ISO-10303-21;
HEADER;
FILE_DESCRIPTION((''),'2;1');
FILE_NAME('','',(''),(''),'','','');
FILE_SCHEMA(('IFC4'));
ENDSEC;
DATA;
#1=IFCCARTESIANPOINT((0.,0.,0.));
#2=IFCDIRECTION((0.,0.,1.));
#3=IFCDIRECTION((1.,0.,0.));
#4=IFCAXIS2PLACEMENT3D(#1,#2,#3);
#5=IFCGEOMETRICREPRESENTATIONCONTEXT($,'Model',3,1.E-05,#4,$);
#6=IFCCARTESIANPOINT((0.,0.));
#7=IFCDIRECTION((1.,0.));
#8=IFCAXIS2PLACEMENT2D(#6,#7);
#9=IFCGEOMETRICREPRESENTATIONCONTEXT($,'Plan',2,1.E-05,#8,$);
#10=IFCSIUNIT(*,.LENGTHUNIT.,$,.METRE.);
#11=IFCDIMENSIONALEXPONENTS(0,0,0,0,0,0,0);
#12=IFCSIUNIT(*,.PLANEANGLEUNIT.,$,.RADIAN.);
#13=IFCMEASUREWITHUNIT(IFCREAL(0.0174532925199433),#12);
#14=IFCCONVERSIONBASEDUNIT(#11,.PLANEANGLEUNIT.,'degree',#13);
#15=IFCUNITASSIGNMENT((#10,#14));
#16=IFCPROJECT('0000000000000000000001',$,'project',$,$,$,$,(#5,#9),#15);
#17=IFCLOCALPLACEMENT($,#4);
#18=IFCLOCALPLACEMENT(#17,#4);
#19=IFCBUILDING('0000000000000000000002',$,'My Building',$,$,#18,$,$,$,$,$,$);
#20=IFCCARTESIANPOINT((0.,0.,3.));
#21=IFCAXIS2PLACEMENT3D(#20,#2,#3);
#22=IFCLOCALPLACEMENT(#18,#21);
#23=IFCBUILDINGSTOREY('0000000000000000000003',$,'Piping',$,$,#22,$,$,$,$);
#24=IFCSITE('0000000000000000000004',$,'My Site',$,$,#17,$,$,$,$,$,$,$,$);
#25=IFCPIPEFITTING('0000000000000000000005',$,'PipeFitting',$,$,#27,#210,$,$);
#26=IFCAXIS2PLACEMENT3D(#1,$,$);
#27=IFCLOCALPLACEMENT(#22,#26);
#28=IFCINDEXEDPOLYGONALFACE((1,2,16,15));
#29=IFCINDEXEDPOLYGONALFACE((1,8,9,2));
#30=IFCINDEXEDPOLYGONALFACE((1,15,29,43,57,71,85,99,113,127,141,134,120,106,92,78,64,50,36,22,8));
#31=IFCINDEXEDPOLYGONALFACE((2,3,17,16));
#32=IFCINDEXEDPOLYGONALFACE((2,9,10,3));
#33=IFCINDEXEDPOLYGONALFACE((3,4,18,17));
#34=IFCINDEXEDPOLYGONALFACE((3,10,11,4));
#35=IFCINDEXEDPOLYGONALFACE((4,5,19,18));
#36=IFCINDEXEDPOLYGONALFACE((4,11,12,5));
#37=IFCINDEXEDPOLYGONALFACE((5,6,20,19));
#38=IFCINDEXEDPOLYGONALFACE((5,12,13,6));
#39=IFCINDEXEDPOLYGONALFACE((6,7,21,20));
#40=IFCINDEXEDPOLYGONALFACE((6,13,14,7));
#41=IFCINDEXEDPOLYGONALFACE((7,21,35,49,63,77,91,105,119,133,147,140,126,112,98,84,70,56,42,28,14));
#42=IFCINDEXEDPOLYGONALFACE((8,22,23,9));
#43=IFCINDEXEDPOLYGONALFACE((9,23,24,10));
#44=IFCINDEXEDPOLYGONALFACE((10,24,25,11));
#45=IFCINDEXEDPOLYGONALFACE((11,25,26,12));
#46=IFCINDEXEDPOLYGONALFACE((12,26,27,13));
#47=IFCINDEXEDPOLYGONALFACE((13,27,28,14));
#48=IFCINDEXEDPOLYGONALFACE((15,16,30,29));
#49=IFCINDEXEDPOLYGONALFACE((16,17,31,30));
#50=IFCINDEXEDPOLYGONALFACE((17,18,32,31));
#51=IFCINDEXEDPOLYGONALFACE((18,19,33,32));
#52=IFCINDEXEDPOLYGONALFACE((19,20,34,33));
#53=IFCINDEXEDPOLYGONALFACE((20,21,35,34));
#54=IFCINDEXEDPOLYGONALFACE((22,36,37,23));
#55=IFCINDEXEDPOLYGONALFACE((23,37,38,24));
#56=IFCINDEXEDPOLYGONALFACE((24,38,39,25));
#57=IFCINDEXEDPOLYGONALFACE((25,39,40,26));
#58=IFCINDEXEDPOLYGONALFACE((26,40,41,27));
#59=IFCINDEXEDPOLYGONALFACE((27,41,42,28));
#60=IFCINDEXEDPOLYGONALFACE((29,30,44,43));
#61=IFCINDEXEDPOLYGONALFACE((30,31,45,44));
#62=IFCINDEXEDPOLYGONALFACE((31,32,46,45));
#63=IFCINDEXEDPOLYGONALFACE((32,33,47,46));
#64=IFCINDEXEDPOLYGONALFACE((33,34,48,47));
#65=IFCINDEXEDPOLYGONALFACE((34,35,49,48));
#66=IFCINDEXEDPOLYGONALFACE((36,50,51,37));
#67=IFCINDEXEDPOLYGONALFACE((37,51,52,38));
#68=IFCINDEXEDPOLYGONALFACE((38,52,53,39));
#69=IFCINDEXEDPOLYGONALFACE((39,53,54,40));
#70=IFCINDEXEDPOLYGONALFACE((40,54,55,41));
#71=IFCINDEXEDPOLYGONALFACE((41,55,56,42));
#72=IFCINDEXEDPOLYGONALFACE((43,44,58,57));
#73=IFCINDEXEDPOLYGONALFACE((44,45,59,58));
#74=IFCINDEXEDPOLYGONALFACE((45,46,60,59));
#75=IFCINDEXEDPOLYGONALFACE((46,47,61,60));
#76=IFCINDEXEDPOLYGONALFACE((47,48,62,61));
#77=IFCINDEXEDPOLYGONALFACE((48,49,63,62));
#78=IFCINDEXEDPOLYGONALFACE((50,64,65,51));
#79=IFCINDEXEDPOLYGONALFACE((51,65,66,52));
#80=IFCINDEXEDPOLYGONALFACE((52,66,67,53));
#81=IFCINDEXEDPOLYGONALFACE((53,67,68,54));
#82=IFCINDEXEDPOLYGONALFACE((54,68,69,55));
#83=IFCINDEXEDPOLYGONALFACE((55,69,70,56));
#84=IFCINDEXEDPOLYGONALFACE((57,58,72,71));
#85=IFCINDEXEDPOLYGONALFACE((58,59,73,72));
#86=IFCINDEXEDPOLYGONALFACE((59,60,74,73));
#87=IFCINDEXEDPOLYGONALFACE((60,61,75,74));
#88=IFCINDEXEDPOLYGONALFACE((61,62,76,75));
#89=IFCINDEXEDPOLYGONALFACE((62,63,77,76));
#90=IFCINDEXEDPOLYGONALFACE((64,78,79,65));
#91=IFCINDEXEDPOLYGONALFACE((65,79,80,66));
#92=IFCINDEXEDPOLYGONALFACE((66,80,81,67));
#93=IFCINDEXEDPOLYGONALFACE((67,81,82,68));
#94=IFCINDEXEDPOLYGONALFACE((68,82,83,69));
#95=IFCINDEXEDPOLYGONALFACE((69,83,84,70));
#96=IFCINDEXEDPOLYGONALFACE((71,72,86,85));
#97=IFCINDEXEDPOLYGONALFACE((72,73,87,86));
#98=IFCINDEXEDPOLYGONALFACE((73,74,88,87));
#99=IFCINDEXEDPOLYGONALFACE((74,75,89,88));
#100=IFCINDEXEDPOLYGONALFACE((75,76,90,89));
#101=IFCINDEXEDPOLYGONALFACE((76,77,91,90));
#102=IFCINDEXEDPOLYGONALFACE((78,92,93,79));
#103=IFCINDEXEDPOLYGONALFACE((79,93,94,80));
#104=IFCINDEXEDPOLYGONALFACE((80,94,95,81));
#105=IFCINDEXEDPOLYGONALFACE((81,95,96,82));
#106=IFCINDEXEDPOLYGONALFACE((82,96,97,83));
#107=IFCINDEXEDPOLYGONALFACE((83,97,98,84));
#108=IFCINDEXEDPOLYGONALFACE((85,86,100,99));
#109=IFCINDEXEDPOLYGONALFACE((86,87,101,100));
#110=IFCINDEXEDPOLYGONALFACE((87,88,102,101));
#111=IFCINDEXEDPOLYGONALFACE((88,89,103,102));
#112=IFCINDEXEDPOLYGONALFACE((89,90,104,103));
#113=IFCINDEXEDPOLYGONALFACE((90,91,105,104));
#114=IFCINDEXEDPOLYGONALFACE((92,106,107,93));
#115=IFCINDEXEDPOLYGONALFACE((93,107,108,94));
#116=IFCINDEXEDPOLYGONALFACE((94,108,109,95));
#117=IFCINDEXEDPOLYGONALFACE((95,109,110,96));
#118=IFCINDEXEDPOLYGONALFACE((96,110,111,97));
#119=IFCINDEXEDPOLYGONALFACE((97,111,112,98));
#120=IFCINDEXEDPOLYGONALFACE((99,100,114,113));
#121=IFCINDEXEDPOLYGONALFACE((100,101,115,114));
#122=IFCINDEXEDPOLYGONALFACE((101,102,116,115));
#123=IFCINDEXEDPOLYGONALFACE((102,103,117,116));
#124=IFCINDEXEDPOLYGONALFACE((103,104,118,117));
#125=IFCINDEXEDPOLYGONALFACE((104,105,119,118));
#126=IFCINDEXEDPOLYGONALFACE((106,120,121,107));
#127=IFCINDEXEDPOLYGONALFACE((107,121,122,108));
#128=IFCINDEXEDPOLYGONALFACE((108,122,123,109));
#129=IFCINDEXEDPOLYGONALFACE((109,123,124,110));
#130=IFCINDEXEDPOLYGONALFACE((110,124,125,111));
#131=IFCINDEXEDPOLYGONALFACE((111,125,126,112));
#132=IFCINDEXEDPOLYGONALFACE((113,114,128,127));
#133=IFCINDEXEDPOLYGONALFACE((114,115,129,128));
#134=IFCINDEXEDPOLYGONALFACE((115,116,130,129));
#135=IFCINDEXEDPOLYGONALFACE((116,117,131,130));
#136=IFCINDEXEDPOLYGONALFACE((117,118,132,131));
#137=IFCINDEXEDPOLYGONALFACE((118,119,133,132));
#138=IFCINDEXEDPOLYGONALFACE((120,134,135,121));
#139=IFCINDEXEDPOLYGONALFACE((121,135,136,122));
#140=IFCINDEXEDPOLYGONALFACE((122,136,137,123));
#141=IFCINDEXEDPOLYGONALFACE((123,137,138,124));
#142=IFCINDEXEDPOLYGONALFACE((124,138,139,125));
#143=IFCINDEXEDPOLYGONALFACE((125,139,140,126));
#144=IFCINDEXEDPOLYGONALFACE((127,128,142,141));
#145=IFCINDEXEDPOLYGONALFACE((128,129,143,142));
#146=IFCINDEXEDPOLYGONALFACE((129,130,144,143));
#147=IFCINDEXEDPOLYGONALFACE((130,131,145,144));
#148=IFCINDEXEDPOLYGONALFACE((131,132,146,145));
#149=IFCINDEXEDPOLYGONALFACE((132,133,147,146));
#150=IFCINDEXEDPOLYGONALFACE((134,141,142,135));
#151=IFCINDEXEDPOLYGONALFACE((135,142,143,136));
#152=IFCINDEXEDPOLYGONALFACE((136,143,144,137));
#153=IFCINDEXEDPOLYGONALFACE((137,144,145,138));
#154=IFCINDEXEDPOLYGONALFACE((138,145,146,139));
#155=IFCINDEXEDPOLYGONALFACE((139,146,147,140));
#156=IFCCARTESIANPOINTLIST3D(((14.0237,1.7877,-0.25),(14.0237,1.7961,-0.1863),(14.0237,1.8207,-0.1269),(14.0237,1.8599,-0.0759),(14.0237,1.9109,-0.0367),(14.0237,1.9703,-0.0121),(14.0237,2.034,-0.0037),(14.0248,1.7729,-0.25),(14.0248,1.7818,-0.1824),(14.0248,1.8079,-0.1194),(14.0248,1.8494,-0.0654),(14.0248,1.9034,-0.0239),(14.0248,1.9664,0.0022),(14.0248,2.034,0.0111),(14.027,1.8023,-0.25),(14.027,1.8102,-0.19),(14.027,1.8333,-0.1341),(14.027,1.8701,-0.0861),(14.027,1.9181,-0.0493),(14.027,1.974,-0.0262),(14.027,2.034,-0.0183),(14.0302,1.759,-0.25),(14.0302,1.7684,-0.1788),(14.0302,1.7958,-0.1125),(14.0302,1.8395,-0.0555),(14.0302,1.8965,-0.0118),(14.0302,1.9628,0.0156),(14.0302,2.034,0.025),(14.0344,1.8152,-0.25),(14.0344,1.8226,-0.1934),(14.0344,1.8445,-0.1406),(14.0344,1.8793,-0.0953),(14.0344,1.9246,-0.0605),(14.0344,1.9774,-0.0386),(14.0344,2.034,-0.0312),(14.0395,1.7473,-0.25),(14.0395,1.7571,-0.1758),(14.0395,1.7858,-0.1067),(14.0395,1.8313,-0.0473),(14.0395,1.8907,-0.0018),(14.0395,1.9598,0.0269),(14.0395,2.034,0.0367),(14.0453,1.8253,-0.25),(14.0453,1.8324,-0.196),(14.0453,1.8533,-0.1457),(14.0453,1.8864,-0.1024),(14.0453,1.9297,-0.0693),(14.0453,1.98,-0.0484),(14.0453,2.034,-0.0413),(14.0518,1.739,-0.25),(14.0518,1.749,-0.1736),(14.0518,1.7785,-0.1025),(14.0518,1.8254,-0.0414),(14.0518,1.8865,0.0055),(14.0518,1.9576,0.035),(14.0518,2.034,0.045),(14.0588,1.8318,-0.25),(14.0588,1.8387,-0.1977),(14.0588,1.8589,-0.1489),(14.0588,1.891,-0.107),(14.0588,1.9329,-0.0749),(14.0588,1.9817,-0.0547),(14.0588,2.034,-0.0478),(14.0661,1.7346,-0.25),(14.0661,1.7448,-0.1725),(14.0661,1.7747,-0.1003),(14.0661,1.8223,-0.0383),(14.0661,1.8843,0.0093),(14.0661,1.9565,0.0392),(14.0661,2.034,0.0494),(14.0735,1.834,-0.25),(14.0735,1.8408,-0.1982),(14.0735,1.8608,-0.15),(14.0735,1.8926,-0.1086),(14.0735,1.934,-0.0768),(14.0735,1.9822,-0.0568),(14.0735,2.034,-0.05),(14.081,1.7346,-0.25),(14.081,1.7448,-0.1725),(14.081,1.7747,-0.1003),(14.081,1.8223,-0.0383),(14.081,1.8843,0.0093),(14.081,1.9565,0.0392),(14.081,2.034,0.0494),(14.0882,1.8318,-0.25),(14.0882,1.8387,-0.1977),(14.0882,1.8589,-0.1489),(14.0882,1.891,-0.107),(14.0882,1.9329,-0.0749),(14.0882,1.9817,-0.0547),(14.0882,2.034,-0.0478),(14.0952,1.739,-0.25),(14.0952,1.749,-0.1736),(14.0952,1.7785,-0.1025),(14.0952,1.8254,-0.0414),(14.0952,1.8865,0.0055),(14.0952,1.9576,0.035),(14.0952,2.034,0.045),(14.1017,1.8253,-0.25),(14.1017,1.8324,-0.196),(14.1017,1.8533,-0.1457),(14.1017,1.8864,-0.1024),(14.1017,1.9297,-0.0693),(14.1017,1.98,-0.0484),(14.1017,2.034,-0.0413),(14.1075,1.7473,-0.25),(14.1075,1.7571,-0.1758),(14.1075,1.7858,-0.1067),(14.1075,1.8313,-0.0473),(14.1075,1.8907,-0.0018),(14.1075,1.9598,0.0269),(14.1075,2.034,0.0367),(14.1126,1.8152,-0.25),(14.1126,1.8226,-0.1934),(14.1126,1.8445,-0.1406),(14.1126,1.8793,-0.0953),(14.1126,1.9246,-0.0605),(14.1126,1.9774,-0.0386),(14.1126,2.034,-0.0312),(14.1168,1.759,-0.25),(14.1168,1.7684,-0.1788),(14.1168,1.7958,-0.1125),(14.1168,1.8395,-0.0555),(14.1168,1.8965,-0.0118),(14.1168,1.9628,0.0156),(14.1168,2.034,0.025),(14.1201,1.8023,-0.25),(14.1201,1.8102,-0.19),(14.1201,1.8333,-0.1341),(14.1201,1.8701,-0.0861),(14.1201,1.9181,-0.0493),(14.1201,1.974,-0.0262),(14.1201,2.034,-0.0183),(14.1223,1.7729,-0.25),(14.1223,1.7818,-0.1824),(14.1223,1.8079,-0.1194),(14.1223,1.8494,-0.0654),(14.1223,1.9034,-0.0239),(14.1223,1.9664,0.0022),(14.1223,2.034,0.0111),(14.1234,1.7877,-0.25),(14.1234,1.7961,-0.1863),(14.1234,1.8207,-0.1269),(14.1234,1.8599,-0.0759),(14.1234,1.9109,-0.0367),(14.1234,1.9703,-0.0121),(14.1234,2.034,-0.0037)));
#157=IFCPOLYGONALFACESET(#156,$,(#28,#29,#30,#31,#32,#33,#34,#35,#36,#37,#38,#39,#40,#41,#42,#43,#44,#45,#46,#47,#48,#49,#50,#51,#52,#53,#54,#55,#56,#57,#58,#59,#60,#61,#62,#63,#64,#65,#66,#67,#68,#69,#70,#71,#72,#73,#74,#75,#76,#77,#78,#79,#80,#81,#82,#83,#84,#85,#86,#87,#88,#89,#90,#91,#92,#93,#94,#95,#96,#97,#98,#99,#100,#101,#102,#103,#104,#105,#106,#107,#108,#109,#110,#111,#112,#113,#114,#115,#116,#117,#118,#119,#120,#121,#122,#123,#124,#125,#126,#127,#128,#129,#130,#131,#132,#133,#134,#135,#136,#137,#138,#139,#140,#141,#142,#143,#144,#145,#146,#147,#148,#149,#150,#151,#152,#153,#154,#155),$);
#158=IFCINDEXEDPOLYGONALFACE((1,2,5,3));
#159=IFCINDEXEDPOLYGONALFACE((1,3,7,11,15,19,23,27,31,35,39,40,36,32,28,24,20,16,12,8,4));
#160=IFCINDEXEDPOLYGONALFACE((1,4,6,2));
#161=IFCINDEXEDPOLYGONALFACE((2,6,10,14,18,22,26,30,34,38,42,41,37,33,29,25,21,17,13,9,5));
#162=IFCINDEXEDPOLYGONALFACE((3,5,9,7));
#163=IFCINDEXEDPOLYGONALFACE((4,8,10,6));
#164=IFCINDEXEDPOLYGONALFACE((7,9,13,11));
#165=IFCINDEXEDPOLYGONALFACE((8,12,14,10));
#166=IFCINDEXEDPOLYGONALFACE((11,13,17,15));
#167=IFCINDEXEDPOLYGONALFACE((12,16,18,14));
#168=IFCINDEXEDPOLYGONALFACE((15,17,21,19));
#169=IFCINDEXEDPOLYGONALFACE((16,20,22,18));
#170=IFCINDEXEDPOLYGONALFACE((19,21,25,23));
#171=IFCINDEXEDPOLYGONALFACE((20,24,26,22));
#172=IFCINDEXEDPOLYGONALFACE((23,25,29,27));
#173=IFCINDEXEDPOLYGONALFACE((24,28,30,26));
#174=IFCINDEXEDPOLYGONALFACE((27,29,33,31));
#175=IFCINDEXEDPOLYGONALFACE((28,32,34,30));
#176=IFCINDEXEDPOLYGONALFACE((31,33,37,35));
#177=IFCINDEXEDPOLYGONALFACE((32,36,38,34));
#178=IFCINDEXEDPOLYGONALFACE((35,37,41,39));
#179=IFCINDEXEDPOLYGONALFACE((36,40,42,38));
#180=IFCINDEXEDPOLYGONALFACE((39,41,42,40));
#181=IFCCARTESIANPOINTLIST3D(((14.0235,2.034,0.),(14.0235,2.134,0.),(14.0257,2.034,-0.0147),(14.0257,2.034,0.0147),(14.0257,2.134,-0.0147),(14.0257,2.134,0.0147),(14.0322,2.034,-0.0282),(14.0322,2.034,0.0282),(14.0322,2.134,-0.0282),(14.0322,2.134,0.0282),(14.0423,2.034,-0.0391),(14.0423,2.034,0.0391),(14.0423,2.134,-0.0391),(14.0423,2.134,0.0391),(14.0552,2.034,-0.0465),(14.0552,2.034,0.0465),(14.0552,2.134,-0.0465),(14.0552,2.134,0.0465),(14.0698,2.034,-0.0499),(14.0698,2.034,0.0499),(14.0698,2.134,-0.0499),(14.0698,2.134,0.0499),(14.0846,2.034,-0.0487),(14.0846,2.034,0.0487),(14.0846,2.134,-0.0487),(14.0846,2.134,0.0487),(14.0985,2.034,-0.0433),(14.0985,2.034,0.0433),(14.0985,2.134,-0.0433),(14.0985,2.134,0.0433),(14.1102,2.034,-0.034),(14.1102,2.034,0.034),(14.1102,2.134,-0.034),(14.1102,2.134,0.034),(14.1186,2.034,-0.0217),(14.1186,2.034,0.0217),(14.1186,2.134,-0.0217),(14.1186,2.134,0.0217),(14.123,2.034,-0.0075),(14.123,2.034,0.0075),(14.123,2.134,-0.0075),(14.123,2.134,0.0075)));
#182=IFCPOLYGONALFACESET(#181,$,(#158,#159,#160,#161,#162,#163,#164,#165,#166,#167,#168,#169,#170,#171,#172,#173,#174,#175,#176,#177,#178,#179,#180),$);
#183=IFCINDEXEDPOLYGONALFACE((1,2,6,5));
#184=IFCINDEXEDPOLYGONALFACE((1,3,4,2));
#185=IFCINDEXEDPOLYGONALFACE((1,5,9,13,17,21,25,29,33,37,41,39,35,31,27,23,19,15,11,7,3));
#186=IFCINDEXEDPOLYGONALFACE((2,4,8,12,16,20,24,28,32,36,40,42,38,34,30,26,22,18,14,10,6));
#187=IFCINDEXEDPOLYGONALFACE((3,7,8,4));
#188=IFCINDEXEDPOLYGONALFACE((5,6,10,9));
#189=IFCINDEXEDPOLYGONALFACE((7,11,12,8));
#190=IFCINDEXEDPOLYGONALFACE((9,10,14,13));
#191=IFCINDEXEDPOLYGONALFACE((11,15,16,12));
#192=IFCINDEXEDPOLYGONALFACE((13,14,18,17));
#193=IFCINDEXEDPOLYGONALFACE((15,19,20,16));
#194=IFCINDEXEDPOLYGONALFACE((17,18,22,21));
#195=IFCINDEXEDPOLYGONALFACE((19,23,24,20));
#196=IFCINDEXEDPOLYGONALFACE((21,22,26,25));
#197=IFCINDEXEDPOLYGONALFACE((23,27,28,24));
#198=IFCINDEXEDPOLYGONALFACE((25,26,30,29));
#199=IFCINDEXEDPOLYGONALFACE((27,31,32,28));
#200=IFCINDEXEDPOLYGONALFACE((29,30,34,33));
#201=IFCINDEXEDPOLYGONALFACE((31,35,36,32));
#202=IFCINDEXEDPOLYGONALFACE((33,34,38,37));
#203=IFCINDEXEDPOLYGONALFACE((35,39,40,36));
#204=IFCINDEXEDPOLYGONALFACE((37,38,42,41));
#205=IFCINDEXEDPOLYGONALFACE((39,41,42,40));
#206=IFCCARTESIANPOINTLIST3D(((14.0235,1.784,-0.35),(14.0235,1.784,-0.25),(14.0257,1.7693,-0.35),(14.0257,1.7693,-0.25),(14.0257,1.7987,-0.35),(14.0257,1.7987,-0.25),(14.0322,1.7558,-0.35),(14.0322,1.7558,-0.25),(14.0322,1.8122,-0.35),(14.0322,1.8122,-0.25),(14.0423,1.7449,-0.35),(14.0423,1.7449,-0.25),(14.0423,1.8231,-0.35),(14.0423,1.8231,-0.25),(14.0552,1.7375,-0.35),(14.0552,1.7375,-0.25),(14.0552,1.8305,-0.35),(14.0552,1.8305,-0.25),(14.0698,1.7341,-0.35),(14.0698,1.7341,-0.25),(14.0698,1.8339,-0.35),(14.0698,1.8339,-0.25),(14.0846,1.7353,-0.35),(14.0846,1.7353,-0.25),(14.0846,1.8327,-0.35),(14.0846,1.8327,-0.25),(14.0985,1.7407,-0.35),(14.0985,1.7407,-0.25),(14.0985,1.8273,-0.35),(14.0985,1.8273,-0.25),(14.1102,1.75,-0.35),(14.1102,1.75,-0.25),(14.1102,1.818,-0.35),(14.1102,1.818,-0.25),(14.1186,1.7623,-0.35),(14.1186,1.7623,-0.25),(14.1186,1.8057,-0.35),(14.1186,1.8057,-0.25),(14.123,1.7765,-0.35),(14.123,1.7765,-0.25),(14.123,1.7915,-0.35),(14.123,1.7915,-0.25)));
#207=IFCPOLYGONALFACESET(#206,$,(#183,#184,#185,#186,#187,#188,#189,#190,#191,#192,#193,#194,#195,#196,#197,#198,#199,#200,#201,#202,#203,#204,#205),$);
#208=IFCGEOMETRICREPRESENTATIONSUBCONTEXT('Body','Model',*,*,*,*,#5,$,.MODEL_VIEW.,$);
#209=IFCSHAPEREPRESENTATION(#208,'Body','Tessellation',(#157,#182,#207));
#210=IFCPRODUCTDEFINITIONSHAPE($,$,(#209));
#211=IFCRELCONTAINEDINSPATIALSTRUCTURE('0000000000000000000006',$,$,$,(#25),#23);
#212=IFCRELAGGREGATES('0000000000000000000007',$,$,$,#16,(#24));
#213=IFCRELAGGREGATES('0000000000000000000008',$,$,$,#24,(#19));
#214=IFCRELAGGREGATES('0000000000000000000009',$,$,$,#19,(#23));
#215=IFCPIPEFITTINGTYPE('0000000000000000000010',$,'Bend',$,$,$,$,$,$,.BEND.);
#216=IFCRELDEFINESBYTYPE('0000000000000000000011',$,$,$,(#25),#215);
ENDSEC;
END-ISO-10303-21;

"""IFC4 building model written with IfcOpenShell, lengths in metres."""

from ifc_helpers import new_model, entity, si_unit, converted_unit, frame, origin_with_axes, origin_2d_with_axis, place, context, subcontext, project, spatial, circle, extrude, source, transform, mapped, type_object, type_shapes, element, save


model = new_model("IFC4")

# Units and contexts
model_context = context("Model", 3, precision=1e-05, world=origin_with_axes())
plan_context = context("Plan", 2, precision=1e-05, world=origin_2d_with_axis())
body_context = subcontext(model_context, "Body", "Model", "MODEL_VIEW")
ifc_project = project(units=[si_unit("LENGTHUNIT", "METRE"), converted_unit("PLANEANGLEUNIT", "degree", entity("IfcReal", 0.0174532925199433), si_unit("PLANEANGLEUNIT", "RADIAN"), dimensions=[0, 0, 0, 0, 0, 0, 0])], contexts=[model_context, plan_context])

# Site, building, storey
site_placement = place(None, origin_with_axes())
site = spatial("IfcSite", under=ifc_project, at=site_placement, Name="My Site")
building_placement = place(site_placement, origin_with_axes())
building = spatial("IfcBuilding", under=site, at=building_placement, Name="My Building")
storey_placement = place(building_placement, frame((0.0, 0.0, 3.0), z_axis=(0.0, 0.0, 1.0), x_axis=(1.0, 0.0, 0.0)))
storey = spatial("IfcBuildingStorey", under=building, at=storey_placement, Name="Piping")

# Pipe fitting
pipe_fitting_type_1 = type_object("IfcPipeFittingType", Name="Bend", PredefinedType="BEND")
shared_shape = source(origin_with_axes(), body_context, "Body", "SolidModel", [
    entity("IfcSweptDiskSolid", entity("IfcIndexedPolyCurve", entity("IfcCartesianPointList3D", [[0.0, 0.0, -0.1], [0.0, -0.0732, -0.2768], [0.0, -0.25, -0.35]]), [entity("IfcArcIndex", [1, 2, 3])]), 0.05),
    extrude(circle(Radius=0.05), origin_with_axes(), (0.0, 0.0, -1.0), 0.1),
    extrude(circle(Radius=0.05), frame((0.0, -0.25, -0.35), z_axis=(0.0, -1.0, 0.0), x_axis=(1.0, 0.0, 0.0)), (0.0, 0.0, 1.0), 0.1),
])
type_shapes(pipe_fitting_type_1, [shared_shape])
for number, where, z_axis, x_axis, name in (
    (1, (14.0735, 2.134, 0.0), (0.0, 1.0, 0.0), (-1.0, 0.0, 0.0), "PipeFitting"),
):
    element("IfcPipeFitting", number, at=place(storey_placement, frame(where, z_axis=z_axis, x_axis=x_axis)), inside=storey, type_object=pipe_fitting_type_1, Name=name, context=body_context, shape_type="MappedRepresentation", body=[
        mapped(shared_shape, transform((0.0, 0.0, 0.0), x_axis=(1.0, 0.0, 0.0), y_axis=(0.0, 1.0, 0.0), z_axis=(0.0, 0.0, 1.0), scale=1.0)),
    ])

save(model, "model.ifc")
